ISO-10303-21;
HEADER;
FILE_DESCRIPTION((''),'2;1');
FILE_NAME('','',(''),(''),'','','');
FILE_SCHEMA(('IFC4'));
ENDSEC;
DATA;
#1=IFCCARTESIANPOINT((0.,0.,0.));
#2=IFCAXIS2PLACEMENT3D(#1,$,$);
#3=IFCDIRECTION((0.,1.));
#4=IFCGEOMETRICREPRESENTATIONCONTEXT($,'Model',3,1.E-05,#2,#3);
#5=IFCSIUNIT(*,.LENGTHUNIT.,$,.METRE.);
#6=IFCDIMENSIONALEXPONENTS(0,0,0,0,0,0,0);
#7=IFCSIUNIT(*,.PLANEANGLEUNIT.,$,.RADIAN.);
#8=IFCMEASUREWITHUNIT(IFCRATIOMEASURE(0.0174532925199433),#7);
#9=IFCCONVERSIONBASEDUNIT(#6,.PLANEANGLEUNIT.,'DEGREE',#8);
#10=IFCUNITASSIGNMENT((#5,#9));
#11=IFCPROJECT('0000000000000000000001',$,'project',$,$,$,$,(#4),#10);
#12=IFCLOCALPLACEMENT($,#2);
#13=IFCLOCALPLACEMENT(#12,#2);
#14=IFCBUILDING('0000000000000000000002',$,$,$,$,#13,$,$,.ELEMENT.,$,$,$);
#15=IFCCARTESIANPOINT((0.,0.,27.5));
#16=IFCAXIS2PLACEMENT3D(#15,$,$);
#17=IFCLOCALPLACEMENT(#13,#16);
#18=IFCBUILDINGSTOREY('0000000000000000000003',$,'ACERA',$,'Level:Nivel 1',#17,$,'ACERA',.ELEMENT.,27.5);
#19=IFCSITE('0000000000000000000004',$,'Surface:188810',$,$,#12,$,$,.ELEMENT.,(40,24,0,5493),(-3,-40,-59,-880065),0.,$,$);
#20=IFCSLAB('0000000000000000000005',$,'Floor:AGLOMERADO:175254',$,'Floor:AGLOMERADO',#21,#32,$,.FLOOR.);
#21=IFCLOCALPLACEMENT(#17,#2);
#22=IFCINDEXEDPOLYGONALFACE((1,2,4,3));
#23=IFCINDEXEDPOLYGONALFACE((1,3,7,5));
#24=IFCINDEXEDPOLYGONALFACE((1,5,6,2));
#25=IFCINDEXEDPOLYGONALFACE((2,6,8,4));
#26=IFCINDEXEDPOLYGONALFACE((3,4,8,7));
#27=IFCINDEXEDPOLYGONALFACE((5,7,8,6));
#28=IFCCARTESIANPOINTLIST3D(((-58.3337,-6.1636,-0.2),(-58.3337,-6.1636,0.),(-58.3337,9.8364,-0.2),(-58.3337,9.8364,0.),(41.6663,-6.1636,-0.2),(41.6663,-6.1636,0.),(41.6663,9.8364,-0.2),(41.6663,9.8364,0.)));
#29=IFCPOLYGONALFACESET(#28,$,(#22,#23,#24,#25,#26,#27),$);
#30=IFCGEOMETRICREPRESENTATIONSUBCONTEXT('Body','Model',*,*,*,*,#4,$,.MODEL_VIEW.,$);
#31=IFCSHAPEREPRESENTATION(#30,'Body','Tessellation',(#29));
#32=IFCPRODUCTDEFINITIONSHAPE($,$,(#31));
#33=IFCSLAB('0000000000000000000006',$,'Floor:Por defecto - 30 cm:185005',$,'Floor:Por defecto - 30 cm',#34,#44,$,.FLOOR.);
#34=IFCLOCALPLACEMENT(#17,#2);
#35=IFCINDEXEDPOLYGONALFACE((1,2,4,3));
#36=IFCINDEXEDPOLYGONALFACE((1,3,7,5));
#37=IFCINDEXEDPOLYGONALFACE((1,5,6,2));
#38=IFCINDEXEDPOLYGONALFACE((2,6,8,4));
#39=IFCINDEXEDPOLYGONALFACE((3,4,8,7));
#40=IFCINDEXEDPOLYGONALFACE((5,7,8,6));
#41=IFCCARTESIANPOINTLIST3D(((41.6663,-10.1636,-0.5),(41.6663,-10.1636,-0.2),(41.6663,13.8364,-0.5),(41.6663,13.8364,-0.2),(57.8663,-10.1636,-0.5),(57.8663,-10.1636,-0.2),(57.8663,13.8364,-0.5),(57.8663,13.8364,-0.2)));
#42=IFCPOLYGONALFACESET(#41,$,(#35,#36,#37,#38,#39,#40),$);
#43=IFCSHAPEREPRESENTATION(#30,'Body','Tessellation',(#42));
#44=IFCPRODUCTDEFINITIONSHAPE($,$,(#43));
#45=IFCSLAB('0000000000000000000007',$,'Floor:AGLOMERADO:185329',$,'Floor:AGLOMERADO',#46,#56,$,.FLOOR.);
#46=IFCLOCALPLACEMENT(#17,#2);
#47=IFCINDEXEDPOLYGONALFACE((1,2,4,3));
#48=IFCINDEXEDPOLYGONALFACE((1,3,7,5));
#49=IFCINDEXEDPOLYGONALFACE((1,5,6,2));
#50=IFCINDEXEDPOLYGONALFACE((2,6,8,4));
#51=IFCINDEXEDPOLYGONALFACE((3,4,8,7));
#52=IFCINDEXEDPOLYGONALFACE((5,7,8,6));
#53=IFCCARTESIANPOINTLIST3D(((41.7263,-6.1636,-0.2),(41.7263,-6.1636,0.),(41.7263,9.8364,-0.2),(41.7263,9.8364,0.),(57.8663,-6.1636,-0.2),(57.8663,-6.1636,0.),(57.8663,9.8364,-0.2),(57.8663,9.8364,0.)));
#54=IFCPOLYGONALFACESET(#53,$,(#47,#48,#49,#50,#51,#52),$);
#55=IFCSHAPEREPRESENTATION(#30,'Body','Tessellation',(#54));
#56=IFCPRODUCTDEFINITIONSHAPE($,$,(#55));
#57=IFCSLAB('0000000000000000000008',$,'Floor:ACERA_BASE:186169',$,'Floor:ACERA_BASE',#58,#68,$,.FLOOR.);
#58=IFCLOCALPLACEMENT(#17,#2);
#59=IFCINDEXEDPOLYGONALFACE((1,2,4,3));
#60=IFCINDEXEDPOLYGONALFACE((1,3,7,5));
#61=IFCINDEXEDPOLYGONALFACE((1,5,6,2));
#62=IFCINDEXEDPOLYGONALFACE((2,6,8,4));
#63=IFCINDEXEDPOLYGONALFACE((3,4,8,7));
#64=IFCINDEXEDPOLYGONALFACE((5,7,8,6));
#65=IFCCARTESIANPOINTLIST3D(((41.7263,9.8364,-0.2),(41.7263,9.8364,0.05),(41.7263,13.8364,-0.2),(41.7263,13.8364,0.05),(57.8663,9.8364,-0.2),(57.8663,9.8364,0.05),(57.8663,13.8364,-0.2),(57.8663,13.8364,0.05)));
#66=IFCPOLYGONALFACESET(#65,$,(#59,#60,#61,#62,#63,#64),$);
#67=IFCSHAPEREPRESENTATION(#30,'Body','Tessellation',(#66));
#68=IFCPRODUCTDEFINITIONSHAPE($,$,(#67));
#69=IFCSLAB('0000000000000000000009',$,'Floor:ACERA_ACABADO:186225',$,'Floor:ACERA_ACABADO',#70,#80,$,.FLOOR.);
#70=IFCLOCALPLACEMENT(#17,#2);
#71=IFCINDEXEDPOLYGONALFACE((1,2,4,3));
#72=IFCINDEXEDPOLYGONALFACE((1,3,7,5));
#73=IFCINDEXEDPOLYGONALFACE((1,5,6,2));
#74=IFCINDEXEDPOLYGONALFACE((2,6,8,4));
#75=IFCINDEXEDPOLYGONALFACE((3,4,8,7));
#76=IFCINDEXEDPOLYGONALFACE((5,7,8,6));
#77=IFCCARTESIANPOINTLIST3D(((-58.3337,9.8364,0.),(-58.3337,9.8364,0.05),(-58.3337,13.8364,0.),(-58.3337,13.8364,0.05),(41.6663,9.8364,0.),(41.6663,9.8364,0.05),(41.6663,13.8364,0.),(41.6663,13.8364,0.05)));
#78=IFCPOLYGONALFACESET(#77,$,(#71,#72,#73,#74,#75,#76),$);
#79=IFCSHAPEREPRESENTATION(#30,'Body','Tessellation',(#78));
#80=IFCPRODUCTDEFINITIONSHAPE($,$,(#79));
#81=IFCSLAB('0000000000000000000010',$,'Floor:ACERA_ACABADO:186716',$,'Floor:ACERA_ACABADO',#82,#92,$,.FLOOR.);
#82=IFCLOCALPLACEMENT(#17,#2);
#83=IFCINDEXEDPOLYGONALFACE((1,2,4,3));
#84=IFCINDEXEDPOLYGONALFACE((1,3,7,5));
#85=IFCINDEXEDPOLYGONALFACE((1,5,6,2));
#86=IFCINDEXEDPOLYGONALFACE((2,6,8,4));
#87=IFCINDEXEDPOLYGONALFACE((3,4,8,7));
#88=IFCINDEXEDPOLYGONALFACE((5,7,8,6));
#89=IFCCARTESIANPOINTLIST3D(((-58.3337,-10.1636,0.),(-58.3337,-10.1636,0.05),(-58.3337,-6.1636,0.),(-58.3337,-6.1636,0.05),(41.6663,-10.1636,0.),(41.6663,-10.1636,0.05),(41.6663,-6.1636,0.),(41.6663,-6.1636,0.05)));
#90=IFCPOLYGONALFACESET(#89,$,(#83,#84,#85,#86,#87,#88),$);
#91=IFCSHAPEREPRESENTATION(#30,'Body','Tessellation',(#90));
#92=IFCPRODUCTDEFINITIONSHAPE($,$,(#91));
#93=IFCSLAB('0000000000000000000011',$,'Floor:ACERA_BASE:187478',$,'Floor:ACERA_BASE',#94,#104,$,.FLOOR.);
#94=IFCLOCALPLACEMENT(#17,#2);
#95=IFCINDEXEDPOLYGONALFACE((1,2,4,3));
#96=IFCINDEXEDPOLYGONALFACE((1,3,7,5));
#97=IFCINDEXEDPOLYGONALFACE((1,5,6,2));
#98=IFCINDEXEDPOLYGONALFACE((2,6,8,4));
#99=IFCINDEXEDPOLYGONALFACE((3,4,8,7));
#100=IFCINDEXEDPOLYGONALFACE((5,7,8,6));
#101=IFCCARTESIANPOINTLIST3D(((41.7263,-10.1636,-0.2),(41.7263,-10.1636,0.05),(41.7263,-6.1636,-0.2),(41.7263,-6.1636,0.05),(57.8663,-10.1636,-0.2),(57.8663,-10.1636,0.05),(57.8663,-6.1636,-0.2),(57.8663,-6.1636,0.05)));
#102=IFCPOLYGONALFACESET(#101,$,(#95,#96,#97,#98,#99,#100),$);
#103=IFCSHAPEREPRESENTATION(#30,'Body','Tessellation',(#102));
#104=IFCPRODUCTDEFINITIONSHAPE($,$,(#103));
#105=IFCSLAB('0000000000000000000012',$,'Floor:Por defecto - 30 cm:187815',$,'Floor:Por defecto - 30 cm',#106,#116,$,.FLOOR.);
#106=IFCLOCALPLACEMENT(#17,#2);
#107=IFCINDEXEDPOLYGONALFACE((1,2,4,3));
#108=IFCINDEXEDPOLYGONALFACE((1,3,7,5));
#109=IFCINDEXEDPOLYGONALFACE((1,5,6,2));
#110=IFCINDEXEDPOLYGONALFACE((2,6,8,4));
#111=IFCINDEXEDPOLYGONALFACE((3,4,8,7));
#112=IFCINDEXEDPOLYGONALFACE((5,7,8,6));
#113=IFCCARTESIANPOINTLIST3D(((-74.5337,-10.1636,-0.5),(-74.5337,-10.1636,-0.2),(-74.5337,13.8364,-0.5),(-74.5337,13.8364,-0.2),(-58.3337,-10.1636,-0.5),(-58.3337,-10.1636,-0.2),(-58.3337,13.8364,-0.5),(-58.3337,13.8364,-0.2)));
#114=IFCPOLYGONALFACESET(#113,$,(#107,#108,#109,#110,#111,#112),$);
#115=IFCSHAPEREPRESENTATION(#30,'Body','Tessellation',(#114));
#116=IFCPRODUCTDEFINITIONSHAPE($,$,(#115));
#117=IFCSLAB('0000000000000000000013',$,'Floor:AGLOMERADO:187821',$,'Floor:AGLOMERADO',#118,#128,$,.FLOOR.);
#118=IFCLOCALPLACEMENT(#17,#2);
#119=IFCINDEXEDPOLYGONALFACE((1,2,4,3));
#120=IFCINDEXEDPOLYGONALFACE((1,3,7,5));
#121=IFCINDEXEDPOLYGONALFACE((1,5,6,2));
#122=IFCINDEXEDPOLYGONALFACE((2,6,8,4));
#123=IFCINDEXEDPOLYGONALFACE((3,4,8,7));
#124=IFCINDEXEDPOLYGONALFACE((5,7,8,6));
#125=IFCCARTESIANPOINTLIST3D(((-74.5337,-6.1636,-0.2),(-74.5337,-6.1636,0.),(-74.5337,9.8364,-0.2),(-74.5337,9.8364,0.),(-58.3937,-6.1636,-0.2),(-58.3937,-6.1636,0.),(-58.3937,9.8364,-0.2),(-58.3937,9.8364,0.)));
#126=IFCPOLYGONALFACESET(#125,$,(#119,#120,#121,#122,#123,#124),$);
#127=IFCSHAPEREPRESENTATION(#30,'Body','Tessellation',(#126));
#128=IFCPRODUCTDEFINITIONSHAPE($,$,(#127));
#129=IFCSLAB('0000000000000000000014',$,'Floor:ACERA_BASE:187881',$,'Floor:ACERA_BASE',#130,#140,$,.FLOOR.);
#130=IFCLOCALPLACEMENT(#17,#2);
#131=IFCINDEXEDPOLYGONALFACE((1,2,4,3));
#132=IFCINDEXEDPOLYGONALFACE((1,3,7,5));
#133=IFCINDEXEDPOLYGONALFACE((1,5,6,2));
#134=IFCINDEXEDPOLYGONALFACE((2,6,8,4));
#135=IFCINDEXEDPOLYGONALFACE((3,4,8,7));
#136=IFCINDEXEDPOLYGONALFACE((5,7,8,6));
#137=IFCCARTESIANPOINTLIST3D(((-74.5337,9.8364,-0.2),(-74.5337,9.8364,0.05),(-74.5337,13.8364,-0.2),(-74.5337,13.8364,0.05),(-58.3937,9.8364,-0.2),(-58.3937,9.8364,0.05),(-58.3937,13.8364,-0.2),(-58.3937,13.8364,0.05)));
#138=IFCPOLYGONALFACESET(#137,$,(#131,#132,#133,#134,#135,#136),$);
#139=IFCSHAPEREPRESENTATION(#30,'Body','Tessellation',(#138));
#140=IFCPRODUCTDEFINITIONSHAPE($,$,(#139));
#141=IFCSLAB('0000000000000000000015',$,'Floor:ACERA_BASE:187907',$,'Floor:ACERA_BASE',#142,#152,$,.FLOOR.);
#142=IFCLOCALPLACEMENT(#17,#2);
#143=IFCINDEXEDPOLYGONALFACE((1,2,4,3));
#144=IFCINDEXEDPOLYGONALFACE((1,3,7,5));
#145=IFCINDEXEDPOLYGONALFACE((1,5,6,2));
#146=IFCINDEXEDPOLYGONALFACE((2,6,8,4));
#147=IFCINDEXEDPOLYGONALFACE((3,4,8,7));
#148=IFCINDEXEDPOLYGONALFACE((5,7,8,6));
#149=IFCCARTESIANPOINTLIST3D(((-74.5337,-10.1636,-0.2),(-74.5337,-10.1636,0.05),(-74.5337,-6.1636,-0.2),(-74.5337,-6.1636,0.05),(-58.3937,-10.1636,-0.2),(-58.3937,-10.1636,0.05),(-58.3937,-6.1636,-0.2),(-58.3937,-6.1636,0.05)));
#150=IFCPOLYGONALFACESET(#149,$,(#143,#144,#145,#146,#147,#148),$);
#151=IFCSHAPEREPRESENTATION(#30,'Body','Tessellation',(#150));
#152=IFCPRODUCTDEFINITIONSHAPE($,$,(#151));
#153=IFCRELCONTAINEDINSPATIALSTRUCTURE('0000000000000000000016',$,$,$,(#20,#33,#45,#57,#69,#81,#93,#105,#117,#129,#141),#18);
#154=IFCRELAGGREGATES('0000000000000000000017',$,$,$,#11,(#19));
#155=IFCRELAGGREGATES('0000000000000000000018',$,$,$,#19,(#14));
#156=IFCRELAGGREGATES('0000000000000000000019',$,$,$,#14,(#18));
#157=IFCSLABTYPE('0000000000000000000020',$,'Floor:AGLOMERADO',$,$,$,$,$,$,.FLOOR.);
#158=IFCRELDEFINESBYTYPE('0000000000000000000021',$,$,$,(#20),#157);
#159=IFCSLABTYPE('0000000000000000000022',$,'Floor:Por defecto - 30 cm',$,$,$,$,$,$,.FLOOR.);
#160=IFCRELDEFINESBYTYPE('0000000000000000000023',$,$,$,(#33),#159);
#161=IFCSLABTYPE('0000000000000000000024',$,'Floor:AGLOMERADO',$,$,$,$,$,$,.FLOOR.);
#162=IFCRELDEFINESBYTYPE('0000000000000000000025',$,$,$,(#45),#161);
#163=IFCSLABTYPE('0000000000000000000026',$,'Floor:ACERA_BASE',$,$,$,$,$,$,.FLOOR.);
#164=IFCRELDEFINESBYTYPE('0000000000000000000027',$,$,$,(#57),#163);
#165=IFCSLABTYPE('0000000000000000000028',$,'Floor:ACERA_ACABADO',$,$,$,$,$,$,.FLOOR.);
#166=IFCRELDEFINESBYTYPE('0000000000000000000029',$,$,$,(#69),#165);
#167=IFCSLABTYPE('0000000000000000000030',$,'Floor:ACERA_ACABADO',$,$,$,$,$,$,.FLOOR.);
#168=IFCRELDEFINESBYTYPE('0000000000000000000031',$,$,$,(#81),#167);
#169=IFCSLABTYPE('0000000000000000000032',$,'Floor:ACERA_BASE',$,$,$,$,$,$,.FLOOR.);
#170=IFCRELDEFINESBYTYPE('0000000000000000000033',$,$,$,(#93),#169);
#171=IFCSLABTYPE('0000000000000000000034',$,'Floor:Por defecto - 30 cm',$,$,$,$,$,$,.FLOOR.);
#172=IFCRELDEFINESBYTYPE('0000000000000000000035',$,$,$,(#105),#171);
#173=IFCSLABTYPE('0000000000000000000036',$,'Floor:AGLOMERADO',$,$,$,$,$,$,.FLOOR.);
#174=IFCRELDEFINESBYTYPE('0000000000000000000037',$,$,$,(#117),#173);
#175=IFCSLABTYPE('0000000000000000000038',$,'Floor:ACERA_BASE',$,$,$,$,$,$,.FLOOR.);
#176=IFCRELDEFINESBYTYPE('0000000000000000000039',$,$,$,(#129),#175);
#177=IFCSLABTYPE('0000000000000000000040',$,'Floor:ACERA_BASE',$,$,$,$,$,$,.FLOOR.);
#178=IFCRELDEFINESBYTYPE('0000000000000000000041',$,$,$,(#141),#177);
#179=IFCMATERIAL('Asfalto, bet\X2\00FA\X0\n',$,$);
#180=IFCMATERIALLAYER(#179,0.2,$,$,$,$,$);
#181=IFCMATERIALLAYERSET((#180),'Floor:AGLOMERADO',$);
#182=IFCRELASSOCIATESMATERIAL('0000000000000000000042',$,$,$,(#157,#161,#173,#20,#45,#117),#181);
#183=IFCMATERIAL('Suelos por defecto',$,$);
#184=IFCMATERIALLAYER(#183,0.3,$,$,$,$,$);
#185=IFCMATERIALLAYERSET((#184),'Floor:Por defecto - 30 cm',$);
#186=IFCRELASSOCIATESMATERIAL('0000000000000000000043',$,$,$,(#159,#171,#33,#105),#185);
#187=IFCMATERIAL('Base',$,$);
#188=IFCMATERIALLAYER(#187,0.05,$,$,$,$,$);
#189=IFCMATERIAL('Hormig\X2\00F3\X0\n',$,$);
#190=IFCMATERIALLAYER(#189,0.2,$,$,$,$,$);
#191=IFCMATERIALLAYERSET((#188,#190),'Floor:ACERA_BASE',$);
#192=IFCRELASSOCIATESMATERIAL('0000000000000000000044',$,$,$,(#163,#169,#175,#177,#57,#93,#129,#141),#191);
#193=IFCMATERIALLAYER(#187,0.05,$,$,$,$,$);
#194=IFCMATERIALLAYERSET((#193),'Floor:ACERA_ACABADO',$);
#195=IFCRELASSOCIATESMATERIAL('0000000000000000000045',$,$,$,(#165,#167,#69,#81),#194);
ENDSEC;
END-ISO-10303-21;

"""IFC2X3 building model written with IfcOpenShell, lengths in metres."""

from ifc_helpers import new_model, entity, si_unit, converted_unit, direction, frame, frame_2d, origin, origin_2d_with_axis, place, context, subcontext, project, spatial, rectangle, extrude, material, layer, layer_set, layer_usage, type_object, element, save


model = new_model("IFC2X3")

# Units and contexts
model_context = context("Model", 3, precision=1e-05, world=origin(), true_north=direction((0.0, 1.0)))
body_context = subcontext(model_context, "Body", "Model", "MODEL_VIEW")
ifc_project = project(units=[si_unit("LENGTHUNIT", "METRE"), converted_unit("PLANEANGLEUNIT", "DEGREE", entity("IfcRatioMeasure", 0.0174532925199433), si_unit("PLANEANGLEUNIT", "RADIAN"), dimensions=[0, 0, 0, 0, 0, 0, 0])], contexts=[model_context])

# Site, building, storey
site_placement = place(None, origin())
site = spatial("IfcSite", under=ifc_project, at=site_placement, Name="Surface:188810", CompositionType="ELEMENT", RefLatitude=(40, 24, 0, 5493), RefLongitude=(-3, -40, -59, -880065), RefElevation=0.0)
building_placement = place(site_placement, origin())
building = spatial("IfcBuilding", under=site, at=building_placement, CompositionType="ELEMENT")
storey_placement = place(building_placement, frame((0.0, 0.0, 27.5)))
storey = spatial("IfcBuildingStorey", under=building, at=storey_placement, Name="ACERA", ObjectType="Level:Nivel 1", LongName="ACERA", CompositionType="ELEMENT", Elevation=27.5)

# Slabs
ifc_material_1 = material(Name="Asfalto, betún")
ifc_layer_1 = layer(ifc_material_1, 0.2)
ifc_layer_set_1 = layer_set([ifc_layer_1], Name="Floor:AGLOMERADO")
ifc_layer_usage_1 = layer_usage(ifc_layer_set_1, "AXIS3", "POSITIVE", 0.0)
slab_type_1 = type_object("IfcSlabType", Name="Floor:AGLOMERADO", PredefinedType="FLOOR", material=ifc_layer_set_1)
slab_1_placement = place(storey_placement, origin())
element("IfcSlab", 1, at=slab_1_placement, inside=storey, type_object=slab_type_1, material=ifc_layer_usage_1, Name="Floor:AGLOMERADO:175254", ObjectType="Floor:AGLOMERADO", PredefinedType="FLOOR", context=body_context, shape_type="SweptSolid", body=[
    extrude(rectangle(XDim=16.0, YDim=100.0, at=origin_2d_with_axis()), frame((-8.3337, 1.8364, 0.0), z_axis=(0.0, 0.0, -1.0), x_axis=(0.0, 1.0, 0.0)), (0.0, 0.0, 1.0), 0.2),
])
ifc_material_2 = material(Name="Suelos por defecto")
ifc_layer_2 = layer(ifc_material_2, 0.3)
ifc_layer_set_2 = layer_set([ifc_layer_2], Name="Floor:Por defecto - 30 cm")
ifc_layer_usage_2 = layer_usage(ifc_layer_set_2, "AXIS3", "POSITIVE", 0.0)
slab_type_2 = type_object("IfcSlabType", Name="Floor:Por defecto - 30 cm", PredefinedType="FLOOR", material=ifc_layer_set_2)
slab_2_placement = place(storey_placement, origin())
element("IfcSlab", 2, at=slab_2_placement, inside=storey, type_object=slab_type_2, material=ifc_layer_usage_2, Name="Floor:Por defecto - 30 cm:185005", ObjectType="Floor:Por defecto - 30 cm", PredefinedType="FLOOR", context=body_context, shape_type="SweptSolid", body=[
    extrude(rectangle(XDim=24.0, YDim=16.2, at=frame_2d((0.0, 0.0), x_axis=(1.0, 0.0))), frame((49.7663, 1.8364, -0.2), z_axis=(0.0, 0.0, -1.0), x_axis=(0.0, 1.0, 0.0)), (0.0, 0.0, 1.0), 0.3),
])
ifc_layer_usage_3 = layer_usage(ifc_layer_set_1, "AXIS3", "POSITIVE", 0.0)
slab_type_3 = type_object("IfcSlabType", Name="Floor:AGLOMERADO", PredefinedType="FLOOR", material=ifc_layer_set_1)
slab_3_placement = place(storey_placement, origin())
element("IfcSlab", 3, at=slab_3_placement, inside=storey, type_object=slab_type_3, material=ifc_layer_usage_3, Name="Floor:AGLOMERADO:185329", ObjectType="Floor:AGLOMERADO", PredefinedType="FLOOR", context=body_context, shape_type="SweptSolid", body=[
    extrude(rectangle(XDim=16.0, YDim=16.14, at=origin_2d_with_axis()), frame((49.7963, 1.8364, 0.0), z_axis=(0.0, 0.0, -1.0), x_axis=(0.0, 1.0, 0.0)), (0.0, 0.0, 1.0), 0.2),
])
ifc_material_3 = material(Name="Base")
ifc_layer_3 = layer(ifc_material_3, 0.05)
ifc_material_4 = material(Name="Hormigón")
ifc_layer_4 = layer(ifc_material_4, 0.2)
ifc_layer_set_3 = layer_set([ifc_layer_3, ifc_layer_4], Name="Floor:ACERA_BASE")
ifc_layer_usage_4 = layer_usage(ifc_layer_set_3, "AXIS3", "POSITIVE", 0.0)
slab_type_4 = type_object("IfcSlabType", Name="Floor:ACERA_BASE", PredefinedType="FLOOR", material=ifc_layer_set_3)
slab_4_placement = place(storey_placement, origin())
element("IfcSlab", 4, at=slab_4_placement, inside=storey, type_object=slab_type_4, material=ifc_layer_usage_4, Name="Floor:ACERA_BASE:186169", ObjectType="Floor:ACERA_BASE", PredefinedType="FLOOR", context=body_context, shape_type="SweptSolid", body=[
    extrude(rectangle(XDim=4.0, YDim=16.14, at=frame_2d((0.0, 0.0), x_axis=(1.0, 0.0))), frame((49.7963, 11.8364, 0.05), z_axis=(0.0, 0.0, -1.0), x_axis=(0.0, 1.0, 0.0)), (0.0, 0.0, 1.0), 0.25),
])
ifc_layer_5 = layer(ifc_material_3, 0.05)
ifc_layer_set_4 = layer_set([ifc_layer_5], Name="Floor:ACERA_ACABADO")
ifc_layer_usage_5 = layer_usage(ifc_layer_set_4, "AXIS3", "POSITIVE", 0.0)
slab_type_5 = type_object("IfcSlabType", Name="Floor:ACERA_ACABADO", PredefinedType="FLOOR", material=ifc_layer_set_4)
slab_5_placement = place(storey_placement, origin())
element("IfcSlab", 5, at=slab_5_placement, inside=storey, type_object=slab_type_5, material=ifc_layer_usage_5, Name="Floor:ACERA_ACABADO:186225", ObjectType="Floor:ACERA_ACABADO", PredefinedType="FLOOR", context=body_context, shape_type="SweptSolid", body=[
    extrude(rectangle(XDim=4.0, YDim=100.0, at=frame_2d((0.0, 0.0), x_axis=(1.0, 0.0))), frame((-8.3337, 11.8364, 0.05), z_axis=(0.0, 0.0, -1.0), x_axis=(0.0, 1.0, 0.0)), (0.0, 0.0, 1.0), 0.05),
])
ifc_layer_usage_6 = layer_usage(ifc_layer_set_4, "AXIS3", "POSITIVE", 0.0)
slab_type_6 = type_object("IfcSlabType", Name="Floor:ACERA_ACABADO", PredefinedType="FLOOR", material=ifc_layer_set_4)
slab_6_placement = place(storey_placement, origin())
element("IfcSlab", 6, at=slab_6_placement, inside=storey, type_object=slab_type_6, material=ifc_layer_usage_6, Name="Floor:ACERA_ACABADO:186716", ObjectType="Floor:ACERA_ACABADO", PredefinedType="FLOOR", context=body_context, shape_type="SweptSolid", body=[
    extrude(rectangle(XDim=4.0, YDim=100.0, at=frame_2d((0.0, 0.0), x_axis=(1.0, 0.0))), frame((-8.3337, -8.1636, 0.05), z_axis=(0.0, 0.0, -1.0), x_axis=(0.0, 1.0, 0.0)), (0.0, 0.0, 1.0), 0.05),
])
ifc_layer_usage_7 = layer_usage(ifc_layer_set_3, "AXIS3", "POSITIVE", 0.0)
slab_type_7 = type_object("IfcSlabType", Name="Floor:ACERA_BASE", PredefinedType="FLOOR", material=ifc_layer_set_3)
slab_7_placement = place(storey_placement, origin())
element("IfcSlab", 7, at=slab_7_placement, inside=storey, type_object=slab_type_7, material=ifc_layer_usage_7, Name="Floor:ACERA_BASE:187478", ObjectType="Floor:ACERA_BASE", PredefinedType="FLOOR", context=body_context, shape_type="SweptSolid", body=[
    extrude(rectangle(XDim=4.0, YDim=16.14, at=frame_2d((0.0, 0.0), x_axis=(1.0, 0.0))), frame((49.7963, -8.1636, 0.05), z_axis=(0.0, 0.0, -1.0), x_axis=(0.0, 1.0, 0.0)), (0.0, 0.0, 1.0), 0.25),
])
ifc_layer_usage_8 = layer_usage(ifc_layer_set_2, "AXIS3", "POSITIVE", 0.0)
slab_type_8 = type_object("IfcSlabType", Name="Floor:Por defecto - 30 cm", PredefinedType="FLOOR", material=ifc_layer_set_2)
slab_8_placement = place(storey_placement, origin())
element("IfcSlab", 8, at=slab_8_placement, inside=storey, type_object=slab_type_8, material=ifc_layer_usage_8, Name="Floor:Por defecto - 30 cm:187815", ObjectType="Floor:Por defecto - 30 cm", PredefinedType="FLOOR", context=body_context, shape_type="SweptSolid", body=[
    extrude(rectangle(XDim=24.0, YDim=16.2, at=frame_2d((0.0, 0.0), x_axis=(1.0, 0.0))), frame((-66.4337, 1.8364, -0.2), z_axis=(0.0, 0.0, -1.0), x_axis=(0.0, 1.0, 0.0)), (0.0, 0.0, 1.0), 0.3),
])
ifc_layer_usage_9 = layer_usage(ifc_layer_set_1, "AXIS3", "POSITIVE", 0.0)
slab_type_9 = type_object("IfcSlabType", Name="Floor:AGLOMERADO", PredefinedType="FLOOR", material=ifc_layer_set_1)
slab_9_placement = place(storey_placement, origin())
element("IfcSlab", 9, at=slab_9_placement, inside=storey, type_object=slab_type_9, material=ifc_layer_usage_9, Name="Floor:AGLOMERADO:187821", ObjectType="Floor:AGLOMERADO", PredefinedType="FLOOR", context=body_context, shape_type="SweptSolid", body=[
    extrude(rectangle(XDim=16.0, YDim=16.14, at=origin_2d_with_axis()), frame((-66.4637, 1.8364, 0.0), z_axis=(0.0, 0.0, -1.0), x_axis=(0.0, 1.0, 0.0)), (0.0, 0.0, 1.0), 0.2),
])
ifc_layer_usage_10 = layer_usage(ifc_layer_set_3, "AXIS3", "POSITIVE", 0.0)
slab_type_10 = type_object("IfcSlabType", Name="Floor:ACERA_BASE", PredefinedType="FLOOR", material=ifc_layer_set_3)
slab_10_placement = place(storey_placement, origin())
element("IfcSlab", 10, at=slab_10_placement, inside=storey, type_object=slab_type_10, material=ifc_layer_usage_10, Name="Floor:ACERA_BASE:187881", ObjectType="Floor:ACERA_BASE", PredefinedType="FLOOR", context=body_context, shape_type="SweptSolid", body=[
    extrude(rectangle(XDim=4.0, YDim=16.14, at=frame_2d((0.0, 0.0), x_axis=(1.0, 0.0))), frame((-66.4637, 11.8364, 0.05), z_axis=(0.0, 0.0, -1.0), x_axis=(0.0, 1.0, 0.0)), (0.0, 0.0, 1.0), 0.25),
])
ifc_layer_usage_11 = layer_usage(ifc_layer_set_3, "AXIS3", "POSITIVE", 0.0)
slab_type_11 = type_object("IfcSlabType", Name="Floor:ACERA_BASE", PredefinedType="FLOOR", material=ifc_layer_set_3)
slab_11_placement = place(storey_placement, origin())
element("IfcSlab", 11, at=slab_11_placement, inside=storey, type_object=slab_type_11, material=ifc_layer_usage_11, Name="Floor:ACERA_BASE:187907", ObjectType="Floor:ACERA_BASE", PredefinedType="FLOOR", context=body_context, shape_type="SweptSolid", body=[
    extrude(rectangle(XDim=4.0, YDim=16.14, at=frame_2d((0.0, 0.0), x_axis=(1.0, 0.0))), frame((-66.4637, -8.1636, 0.05), z_axis=(0.0, 0.0, -1.0), x_axis=(0.0, 1.0, 0.0)), (0.0, 0.0, 1.0), 0.25),
])

save(model, "model.ifc")
